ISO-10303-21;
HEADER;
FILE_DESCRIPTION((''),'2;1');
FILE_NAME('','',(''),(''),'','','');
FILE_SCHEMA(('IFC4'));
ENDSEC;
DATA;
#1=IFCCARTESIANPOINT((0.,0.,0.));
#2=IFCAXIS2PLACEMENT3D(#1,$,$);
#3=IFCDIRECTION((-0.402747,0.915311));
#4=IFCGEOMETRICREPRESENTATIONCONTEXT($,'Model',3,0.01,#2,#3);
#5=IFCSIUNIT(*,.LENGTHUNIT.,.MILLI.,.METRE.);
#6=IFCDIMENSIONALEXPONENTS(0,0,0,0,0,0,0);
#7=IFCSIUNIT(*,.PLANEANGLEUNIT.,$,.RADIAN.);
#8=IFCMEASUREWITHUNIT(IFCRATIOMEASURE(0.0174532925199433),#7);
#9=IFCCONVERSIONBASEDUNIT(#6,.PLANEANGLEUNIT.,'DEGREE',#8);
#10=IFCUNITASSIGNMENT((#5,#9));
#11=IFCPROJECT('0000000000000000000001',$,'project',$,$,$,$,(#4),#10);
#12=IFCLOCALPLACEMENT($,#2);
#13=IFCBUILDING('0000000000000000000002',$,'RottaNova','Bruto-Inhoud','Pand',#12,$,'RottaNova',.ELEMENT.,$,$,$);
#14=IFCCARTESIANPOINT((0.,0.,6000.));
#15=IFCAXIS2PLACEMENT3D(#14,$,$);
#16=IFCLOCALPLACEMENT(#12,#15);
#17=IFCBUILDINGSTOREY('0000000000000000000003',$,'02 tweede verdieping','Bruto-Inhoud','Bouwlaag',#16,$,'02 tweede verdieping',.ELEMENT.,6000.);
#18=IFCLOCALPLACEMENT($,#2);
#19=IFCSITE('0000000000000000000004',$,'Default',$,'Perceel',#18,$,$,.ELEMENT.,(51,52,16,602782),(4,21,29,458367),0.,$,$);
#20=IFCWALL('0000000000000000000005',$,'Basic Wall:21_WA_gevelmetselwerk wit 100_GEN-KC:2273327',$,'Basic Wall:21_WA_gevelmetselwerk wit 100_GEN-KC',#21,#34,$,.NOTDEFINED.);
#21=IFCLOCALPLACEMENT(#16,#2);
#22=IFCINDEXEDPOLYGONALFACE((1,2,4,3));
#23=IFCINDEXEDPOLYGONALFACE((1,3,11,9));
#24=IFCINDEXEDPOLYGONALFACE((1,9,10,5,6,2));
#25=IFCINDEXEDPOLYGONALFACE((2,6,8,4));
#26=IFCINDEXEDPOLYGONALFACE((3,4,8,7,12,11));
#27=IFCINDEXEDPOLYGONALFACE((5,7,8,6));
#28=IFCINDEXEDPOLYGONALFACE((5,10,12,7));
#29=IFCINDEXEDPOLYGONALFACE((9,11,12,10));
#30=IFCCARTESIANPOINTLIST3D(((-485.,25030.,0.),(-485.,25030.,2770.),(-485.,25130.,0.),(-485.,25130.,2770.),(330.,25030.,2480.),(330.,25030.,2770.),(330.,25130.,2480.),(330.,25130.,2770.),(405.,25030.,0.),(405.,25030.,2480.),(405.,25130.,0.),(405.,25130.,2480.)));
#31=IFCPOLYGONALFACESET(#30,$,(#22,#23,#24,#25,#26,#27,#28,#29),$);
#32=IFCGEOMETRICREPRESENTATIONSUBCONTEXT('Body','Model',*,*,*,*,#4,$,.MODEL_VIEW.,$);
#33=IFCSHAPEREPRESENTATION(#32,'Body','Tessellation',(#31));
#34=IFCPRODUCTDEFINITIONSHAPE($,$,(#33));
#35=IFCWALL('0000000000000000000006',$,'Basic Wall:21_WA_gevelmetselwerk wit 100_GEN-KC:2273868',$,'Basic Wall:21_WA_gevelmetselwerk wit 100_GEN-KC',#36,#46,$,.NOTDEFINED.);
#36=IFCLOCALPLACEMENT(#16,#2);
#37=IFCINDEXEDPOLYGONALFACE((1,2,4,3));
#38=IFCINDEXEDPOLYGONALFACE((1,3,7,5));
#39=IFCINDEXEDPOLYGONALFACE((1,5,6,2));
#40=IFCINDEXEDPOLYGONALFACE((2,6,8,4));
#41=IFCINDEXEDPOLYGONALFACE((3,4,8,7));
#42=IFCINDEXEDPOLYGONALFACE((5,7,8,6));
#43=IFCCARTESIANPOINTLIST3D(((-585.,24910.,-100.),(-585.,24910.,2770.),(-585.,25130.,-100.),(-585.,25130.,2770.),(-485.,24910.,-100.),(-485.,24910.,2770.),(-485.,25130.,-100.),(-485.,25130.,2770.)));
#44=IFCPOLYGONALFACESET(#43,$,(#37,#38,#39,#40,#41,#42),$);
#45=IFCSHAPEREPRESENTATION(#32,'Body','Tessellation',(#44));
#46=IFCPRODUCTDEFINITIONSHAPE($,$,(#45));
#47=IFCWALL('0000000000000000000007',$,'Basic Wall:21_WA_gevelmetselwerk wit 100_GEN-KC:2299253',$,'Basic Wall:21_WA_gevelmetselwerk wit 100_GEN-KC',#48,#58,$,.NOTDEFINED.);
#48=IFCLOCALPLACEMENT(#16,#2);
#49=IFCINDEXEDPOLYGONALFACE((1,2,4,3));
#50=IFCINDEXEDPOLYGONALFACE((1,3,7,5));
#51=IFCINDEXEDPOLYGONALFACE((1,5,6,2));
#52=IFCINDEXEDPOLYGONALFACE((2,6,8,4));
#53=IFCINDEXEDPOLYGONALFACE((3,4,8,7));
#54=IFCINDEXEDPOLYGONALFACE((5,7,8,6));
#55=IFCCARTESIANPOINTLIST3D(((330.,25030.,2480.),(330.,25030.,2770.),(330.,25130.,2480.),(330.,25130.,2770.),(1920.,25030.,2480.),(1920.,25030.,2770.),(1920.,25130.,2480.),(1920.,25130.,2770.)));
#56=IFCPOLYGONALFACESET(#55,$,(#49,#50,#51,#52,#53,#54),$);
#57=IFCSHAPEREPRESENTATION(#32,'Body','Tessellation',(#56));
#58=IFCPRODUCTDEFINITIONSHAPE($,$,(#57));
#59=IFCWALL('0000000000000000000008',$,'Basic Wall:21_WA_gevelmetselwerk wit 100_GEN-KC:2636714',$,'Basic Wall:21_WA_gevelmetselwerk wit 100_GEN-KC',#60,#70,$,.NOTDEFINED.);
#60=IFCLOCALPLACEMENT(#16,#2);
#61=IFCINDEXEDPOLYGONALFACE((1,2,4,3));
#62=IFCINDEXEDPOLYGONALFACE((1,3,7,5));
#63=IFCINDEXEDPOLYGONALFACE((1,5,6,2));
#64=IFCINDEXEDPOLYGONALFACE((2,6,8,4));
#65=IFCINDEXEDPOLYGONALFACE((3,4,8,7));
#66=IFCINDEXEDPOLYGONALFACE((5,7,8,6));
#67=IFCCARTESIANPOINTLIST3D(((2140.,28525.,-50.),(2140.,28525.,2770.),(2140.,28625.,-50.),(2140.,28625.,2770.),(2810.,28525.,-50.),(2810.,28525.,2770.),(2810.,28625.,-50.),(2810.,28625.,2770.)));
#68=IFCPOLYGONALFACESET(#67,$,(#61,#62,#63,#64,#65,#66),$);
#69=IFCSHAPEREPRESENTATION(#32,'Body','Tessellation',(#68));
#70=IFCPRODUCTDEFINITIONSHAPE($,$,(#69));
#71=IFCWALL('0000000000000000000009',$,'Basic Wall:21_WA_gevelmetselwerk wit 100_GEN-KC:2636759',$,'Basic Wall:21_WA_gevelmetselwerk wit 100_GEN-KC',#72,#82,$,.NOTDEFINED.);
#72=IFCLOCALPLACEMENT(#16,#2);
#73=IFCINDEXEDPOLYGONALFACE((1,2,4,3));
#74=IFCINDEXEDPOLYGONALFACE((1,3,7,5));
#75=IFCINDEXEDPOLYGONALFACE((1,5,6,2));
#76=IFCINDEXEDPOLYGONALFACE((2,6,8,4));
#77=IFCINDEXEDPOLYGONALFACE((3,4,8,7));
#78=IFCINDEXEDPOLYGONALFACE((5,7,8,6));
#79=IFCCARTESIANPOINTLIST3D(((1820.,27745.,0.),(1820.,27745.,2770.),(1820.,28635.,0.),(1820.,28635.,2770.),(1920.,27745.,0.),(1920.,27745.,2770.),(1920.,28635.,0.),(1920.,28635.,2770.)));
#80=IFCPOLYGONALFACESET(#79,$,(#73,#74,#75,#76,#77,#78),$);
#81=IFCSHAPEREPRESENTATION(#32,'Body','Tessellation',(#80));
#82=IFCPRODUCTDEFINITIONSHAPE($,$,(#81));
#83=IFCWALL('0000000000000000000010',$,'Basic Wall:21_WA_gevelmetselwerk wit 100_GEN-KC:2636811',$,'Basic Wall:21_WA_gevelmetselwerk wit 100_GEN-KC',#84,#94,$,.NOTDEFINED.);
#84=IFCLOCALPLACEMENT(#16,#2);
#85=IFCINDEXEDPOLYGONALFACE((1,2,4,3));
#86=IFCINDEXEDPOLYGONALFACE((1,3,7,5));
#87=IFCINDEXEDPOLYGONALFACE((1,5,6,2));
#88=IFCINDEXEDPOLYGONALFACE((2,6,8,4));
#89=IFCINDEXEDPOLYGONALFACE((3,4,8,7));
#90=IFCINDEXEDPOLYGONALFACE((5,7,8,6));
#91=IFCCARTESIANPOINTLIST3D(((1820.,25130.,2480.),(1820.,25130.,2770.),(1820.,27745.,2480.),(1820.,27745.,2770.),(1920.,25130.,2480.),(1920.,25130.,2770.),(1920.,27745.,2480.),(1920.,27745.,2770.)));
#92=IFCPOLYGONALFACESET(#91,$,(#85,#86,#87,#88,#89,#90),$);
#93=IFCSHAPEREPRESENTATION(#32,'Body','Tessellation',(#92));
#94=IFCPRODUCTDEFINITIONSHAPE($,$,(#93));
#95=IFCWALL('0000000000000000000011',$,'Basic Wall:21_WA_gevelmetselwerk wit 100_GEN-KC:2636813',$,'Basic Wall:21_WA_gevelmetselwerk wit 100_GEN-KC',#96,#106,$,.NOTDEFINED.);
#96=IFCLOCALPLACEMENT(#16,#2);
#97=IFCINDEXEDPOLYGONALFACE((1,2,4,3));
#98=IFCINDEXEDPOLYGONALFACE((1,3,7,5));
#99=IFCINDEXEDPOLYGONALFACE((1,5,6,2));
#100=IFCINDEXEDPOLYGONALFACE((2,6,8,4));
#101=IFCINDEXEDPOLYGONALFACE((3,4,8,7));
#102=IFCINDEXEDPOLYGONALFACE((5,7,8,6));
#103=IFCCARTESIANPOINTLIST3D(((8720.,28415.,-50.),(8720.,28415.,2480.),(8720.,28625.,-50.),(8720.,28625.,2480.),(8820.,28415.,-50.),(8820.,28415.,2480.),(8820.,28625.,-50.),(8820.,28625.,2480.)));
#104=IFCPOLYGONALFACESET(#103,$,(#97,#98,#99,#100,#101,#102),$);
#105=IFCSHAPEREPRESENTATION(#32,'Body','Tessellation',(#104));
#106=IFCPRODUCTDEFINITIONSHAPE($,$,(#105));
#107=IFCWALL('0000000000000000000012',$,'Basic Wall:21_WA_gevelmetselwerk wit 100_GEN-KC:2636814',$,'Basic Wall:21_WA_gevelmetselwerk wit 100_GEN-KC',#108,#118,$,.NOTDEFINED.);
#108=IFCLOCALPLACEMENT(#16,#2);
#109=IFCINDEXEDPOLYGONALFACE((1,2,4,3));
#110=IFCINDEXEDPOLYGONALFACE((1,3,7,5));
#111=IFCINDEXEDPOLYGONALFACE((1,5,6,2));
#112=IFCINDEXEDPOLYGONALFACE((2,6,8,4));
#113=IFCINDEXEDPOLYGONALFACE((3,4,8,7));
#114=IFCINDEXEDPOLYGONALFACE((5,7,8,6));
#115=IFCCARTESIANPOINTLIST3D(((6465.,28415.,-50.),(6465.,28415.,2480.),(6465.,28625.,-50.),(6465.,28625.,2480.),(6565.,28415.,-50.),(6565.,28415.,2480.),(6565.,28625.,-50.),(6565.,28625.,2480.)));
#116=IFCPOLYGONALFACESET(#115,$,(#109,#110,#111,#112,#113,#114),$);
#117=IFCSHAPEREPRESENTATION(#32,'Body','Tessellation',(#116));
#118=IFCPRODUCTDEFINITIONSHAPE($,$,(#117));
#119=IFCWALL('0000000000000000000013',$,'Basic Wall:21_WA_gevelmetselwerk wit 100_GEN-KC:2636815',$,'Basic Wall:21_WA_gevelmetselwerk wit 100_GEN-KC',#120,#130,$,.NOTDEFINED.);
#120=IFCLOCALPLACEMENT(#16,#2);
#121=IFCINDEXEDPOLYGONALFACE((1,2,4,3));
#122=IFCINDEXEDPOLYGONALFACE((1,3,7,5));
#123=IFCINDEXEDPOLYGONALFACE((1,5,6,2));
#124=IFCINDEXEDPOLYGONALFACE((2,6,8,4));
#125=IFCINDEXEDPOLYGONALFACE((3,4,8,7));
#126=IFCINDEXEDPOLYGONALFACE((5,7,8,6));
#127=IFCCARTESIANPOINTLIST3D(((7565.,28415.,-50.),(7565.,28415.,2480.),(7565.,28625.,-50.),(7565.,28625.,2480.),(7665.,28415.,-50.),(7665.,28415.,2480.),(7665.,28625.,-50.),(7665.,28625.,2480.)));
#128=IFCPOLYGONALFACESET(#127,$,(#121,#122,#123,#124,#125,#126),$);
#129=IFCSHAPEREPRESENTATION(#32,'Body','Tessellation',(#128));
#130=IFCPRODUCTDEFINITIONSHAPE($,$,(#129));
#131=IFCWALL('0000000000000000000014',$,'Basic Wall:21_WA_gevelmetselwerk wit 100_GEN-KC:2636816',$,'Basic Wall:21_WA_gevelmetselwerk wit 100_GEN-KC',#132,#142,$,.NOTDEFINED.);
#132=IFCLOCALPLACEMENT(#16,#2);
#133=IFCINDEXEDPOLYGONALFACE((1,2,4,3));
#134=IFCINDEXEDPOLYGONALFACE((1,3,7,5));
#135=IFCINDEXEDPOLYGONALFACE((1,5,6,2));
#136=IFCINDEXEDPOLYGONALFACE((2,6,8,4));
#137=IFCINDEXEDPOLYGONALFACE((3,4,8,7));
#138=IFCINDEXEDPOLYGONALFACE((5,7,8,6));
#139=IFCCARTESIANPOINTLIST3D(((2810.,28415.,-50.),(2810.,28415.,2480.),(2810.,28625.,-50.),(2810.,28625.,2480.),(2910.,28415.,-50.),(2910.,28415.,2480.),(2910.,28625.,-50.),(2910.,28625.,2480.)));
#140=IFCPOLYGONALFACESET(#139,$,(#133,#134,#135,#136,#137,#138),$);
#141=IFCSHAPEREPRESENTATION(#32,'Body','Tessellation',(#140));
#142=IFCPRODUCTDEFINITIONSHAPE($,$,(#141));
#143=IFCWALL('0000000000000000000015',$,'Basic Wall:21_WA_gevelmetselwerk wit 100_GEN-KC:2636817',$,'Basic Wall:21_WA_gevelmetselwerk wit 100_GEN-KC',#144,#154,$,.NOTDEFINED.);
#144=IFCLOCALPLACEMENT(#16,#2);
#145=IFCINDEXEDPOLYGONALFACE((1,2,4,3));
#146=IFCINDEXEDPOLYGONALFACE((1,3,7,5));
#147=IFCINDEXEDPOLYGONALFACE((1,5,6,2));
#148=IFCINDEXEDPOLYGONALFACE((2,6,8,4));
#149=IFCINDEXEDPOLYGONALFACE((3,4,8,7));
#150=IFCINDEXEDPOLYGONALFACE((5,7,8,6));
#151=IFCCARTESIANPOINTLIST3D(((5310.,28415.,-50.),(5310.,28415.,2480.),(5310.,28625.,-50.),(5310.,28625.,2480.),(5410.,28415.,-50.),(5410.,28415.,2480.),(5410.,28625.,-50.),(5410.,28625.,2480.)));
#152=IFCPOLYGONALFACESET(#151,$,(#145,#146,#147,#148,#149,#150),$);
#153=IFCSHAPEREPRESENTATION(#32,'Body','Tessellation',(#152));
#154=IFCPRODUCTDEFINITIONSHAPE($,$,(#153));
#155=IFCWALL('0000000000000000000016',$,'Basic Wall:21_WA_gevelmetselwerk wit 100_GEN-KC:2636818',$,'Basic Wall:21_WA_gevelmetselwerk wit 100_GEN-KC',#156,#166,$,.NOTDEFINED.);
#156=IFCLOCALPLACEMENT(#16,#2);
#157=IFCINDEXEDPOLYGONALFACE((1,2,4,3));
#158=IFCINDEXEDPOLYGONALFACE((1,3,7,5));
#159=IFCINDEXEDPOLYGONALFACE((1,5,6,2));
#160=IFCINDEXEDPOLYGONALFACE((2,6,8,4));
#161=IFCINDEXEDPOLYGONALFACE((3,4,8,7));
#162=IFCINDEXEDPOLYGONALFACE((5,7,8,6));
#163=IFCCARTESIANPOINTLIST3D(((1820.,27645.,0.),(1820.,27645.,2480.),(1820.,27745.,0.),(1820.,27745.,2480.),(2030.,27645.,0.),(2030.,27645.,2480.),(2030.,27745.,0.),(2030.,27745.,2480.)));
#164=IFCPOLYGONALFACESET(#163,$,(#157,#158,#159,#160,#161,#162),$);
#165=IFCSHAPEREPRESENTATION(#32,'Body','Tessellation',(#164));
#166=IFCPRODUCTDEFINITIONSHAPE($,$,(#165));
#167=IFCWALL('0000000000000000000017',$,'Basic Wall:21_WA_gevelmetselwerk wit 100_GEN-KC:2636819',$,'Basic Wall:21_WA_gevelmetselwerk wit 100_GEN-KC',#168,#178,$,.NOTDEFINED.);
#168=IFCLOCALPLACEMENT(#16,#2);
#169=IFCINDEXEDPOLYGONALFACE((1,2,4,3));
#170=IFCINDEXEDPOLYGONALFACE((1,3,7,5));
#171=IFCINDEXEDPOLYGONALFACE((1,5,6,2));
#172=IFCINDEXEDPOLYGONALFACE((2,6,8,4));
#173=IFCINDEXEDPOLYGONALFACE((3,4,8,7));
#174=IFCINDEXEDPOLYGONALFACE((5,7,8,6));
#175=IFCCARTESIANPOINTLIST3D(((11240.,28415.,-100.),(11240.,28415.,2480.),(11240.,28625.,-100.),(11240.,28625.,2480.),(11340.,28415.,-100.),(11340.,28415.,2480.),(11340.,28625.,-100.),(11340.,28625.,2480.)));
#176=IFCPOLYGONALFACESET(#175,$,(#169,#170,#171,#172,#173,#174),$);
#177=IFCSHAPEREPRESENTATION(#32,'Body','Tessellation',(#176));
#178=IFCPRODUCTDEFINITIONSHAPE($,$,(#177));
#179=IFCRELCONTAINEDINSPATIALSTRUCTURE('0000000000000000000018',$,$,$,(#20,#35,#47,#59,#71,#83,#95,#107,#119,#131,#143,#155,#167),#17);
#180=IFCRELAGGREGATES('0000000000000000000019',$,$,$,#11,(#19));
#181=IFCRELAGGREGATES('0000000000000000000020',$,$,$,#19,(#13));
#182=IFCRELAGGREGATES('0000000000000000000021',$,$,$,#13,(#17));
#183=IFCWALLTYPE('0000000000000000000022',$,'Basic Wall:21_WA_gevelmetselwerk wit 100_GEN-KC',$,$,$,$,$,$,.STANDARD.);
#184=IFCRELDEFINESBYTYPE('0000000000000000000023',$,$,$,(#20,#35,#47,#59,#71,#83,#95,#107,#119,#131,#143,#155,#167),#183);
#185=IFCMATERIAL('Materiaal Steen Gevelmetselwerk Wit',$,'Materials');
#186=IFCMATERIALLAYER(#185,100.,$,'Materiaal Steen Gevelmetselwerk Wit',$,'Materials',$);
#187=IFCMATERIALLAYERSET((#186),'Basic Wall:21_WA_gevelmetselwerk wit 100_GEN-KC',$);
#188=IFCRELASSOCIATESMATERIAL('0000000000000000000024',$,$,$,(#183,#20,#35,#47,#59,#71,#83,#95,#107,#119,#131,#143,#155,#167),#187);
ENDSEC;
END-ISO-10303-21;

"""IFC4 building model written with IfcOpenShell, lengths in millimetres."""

from ifc_helpers import new_model, entity, si_unit, converted_unit, direction, frame, frame_2d, origin, place, context, subcontext, project, spatial, polyline, rectangle, extrude, clip, bounded_halfspace, material, layer, layer_set, type_object, element, save


model = new_model("IFC4")

# Units and contexts
model_context = context("Model", 3, precision=0.01, world=origin(), true_north=direction((-0.402747, 0.915311)))
body_context = subcontext(model_context, "Body", "Model", "MODEL_VIEW")
ifc_project = project(units=[si_unit("LENGTHUNIT", "METRE", prefix="MILLI"), converted_unit("PLANEANGLEUNIT", "DEGREE", entity("IfcRatioMeasure", 0.0174532925199433), si_unit("PLANEANGLEUNIT", "RADIAN"), dimensions=[0, 0, 0, 0, 0, 0, 0])], contexts=[model_context])

# Site, building, storey
site_placement = place(None, origin())
site = spatial("IfcSite", under=ifc_project, at=site_placement, Name="Default", ObjectType="Perceel", CompositionType="ELEMENT", RefLatitude=(51, 52, 16, 602782), RefLongitude=(4, 21, 29, 458367), RefElevation=0.0)
building_placement = place(None, origin())
building = spatial("IfcBuilding", under=site, at=building_placement, Name="RottaNova", Description="Bruto-Inhoud", ObjectType="Pand", LongName="RottaNova", CompositionType="ELEMENT")
storey_placement = place(building_placement, frame((0.0, 0.0, 6000.0)))
storey = spatial("IfcBuildingStorey", under=building, at=storey_placement, Name="02 tweede verdieping", Description="Bruto-Inhoud", ObjectType="Bouwlaag", LongName="02 tweede verdieping", CompositionType="ELEMENT", Elevation=6000.0)

# Walls
ifc_material = material(Name="Materiaal Steen Gevelmetselwerk Wit", Category="Materials")
ifc_layer = layer(ifc_material, 100.0, Name="Materiaal Steen Gevelmetselwerk Wit", Category="Materials")
ifc_layer_set = layer_set([ifc_layer], Name="Basic Wall:21_WA_gevelmetselwerk wit 100_GEN-KC")
wall_type = type_object("IfcWallType", Name="Basic Wall:21_WA_gevelmetselwerk wit 100_GEN-KC", PredefinedType="STANDARD", material=ifc_layer_set)
wall_1_placement = place(storey_placement, frame((-485.0, 25080.0, 0.0)))
element("IfcWall", 1, at=wall_1_placement, inside=storey, type_object=wall_type, material=ifc_layer_set, Name="Basic Wall:21_WA_gevelmetselwerk wit 100_GEN-KC:2273327", ObjectType="Basic Wall:21_WA_gevelmetselwerk wit 100_GEN-KC", PredefinedType="NOTDEFINED", context=body_context, shape_type="Clipping", body=[
    clip(clip(extrude(rectangle(XDim=890.0, YDim=100.0, at=frame_2d((445.0, 0.0), x_axis=(-1.0, 0.0))), origin(), (0.0, 0.0, 1.0), 2770.0), bounded_halfspace(frame((815.0, 50.0, 2480.0), z_axis=(0.0, 0.0, -1.0), x_axis=(0.0, 1.0, 0.0)), True, frame((815.0, 50.0, 2480.0), z_axis=(0.0, 0.0, -1.0), x_axis=(0.0, 1.0, 0.0)), polyline([(0.0, 0.0), (0.0, 75.0), (-100.0, 75.0), (-100.0, 0.0), (0.0, 0.0)]))), bounded_halfspace(frame((815.0, -50.0, 2480.0), z_axis=(-1.0, 0.0, 0.0), x_axis=(0.0, 1.0, 0.0)), True, frame((815.0, -50.0, 2480.0), z_axis=(-1.0, 0.0, 0.0), x_axis=(0.0, 1.0, 0.0)), polyline([(0.0, 0.0), (0.0, -88392.0), (30480.0, -88392.0), (30480.0, 0.0), (0.0, 0.0)]))),
])
wall_2_placement = place(storey_placement, frame((-535.0, 25130.0, -100.0), z_axis=(0.0, 0.0, 1.0), x_axis=(0.0, -1.0, 0.0)))
element("IfcWall", 2, at=wall_2_placement, inside=storey, type_object=wall_type, material=ifc_layer_set, Name="Basic Wall:21_WA_gevelmetselwerk wit 100_GEN-KC:2273868", ObjectType="Basic Wall:21_WA_gevelmetselwerk wit 100_GEN-KC", PredefinedType="NOTDEFINED", context=body_context, shape_type="SweptSolid", body=[
    extrude(rectangle(XDim=220.0, YDim=100.0, at=frame_2d((110.0, 0.0), x_axis=(-1.0, 0.0))), origin(), (0.0, 0.0, 1.0), 2870.0),
])
wall_3_placement = place(storey_placement, frame((330.0, 25080.0, 2480.0)))
element("IfcWall", 3, at=wall_3_placement, inside=storey, type_object=wall_type, material=ifc_layer_set, Name="Basic Wall:21_WA_gevelmetselwerk wit 100_GEN-KC:2299253", ObjectType="Basic Wall:21_WA_gevelmetselwerk wit 100_GEN-KC", PredefinedType="NOTDEFINED", context=body_context, shape_type="SweptSolid", body=[
    extrude(rectangle(XDim=1590.0, YDim=100.0, at=frame_2d((795.0, 0.0), x_axis=(-1.0, 0.0))), origin(), (0.0, 0.0, 1.0), 290.0),
])
wall_4_placement = place(storey_placement, frame((2140.0, 28575.0, -50.0)))
element("IfcWall", 4, at=wall_4_placement, inside=storey, type_object=wall_type, material=ifc_layer_set, Name="Basic Wall:21_WA_gevelmetselwerk wit 100_GEN-KC:2636714", ObjectType="Basic Wall:21_WA_gevelmetselwerk wit 100_GEN-KC", PredefinedType="NOTDEFINED", context=body_context, shape_type="SweptSolid", body=[
    extrude(rectangle(XDim=670.0, YDim=100.0, at=frame_2d((335.0, 0.0), x_axis=(-1.0, 0.0))), origin(), (0.0, 0.0, 1.0), 2820.0),
])
wall_5_placement = place(storey_placement, frame((1870.0, 27745.0, 0.0), z_axis=(0.0, 0.0, 1.0), x_axis=(0.0, 1.0, 0.0)))
element("IfcWall", 5, at=wall_5_placement, inside=storey, type_object=wall_type, material=ifc_layer_set, Name="Basic Wall:21_WA_gevelmetselwerk wit 100_GEN-KC:2636759", ObjectType="Basic Wall:21_WA_gevelmetselwerk wit 100_GEN-KC", PredefinedType="NOTDEFINED", context=body_context, shape_type="SweptSolid", body=[
    extrude(rectangle(XDim=890.0, YDim=100.0, at=frame_2d((445.0, 0.0), x_axis=(-1.0, 0.0))), origin(), (0.0, 0.0, 1.0), 2770.0),
])
wall_6_placement = place(storey_placement, frame((1870.0, 25130.0, 2480.0), z_axis=(0.0, 0.0, 1.0), x_axis=(0.0, 1.0, 0.0)))
element("IfcWall", 6, at=wall_6_placement, inside=storey, type_object=wall_type, material=ifc_layer_set, Name="Basic Wall:21_WA_gevelmetselwerk wit 100_GEN-KC:2636811", ObjectType="Basic Wall:21_WA_gevelmetselwerk wit 100_GEN-KC", PredefinedType="NOTDEFINED", context=body_context, shape_type="SweptSolid", body=[
    extrude(rectangle(XDim=2615.0, YDim=100.0, at=frame_2d((1307.5, 0.0), x_axis=(-1.0, 0.0))), origin(), (0.0, 0.0, 1.0), 290.0),
])
wall_7_placement = place(storey_placement, frame((8770.0, 28415.0, -50.0), z_axis=(0.0, 0.0, 1.0), x_axis=(0.0, 1.0, 0.0)))
element("IfcWall", 7, at=wall_7_placement, inside=storey, type_object=wall_type, material=ifc_layer_set, Name="Basic Wall:21_WA_gevelmetselwerk wit 100_GEN-KC:2636813", ObjectType="Basic Wall:21_WA_gevelmetselwerk wit 100_GEN-KC", PredefinedType="NOTDEFINED", context=body_context, shape_type="SweptSolid", body=[
    extrude(rectangle(XDim=210.0, YDim=100.0, at=frame_2d((105.0, 0.0), x_axis=(-1.0, 0.0))), origin(), (0.0, 0.0, 1.0), 2530.0),
])
wall_8_placement = place(storey_placement, frame((6515.0, 28415.0, -50.0), z_axis=(0.0, 0.0, 1.0), x_axis=(0.0, 1.0, 0.0)))
element("IfcWall", 8, at=wall_8_placement, inside=storey, type_object=wall_type, material=ifc_layer_set, Name="Basic Wall:21_WA_gevelmetselwerk wit 100_GEN-KC:2636814", ObjectType="Basic Wall:21_WA_gevelmetselwerk wit 100_GEN-KC", PredefinedType="NOTDEFINED", context=body_context, shape_type="SweptSolid", body=[
    extrude(rectangle(XDim=210.0, YDim=100.0, at=frame_2d((105.0, 0.0), x_axis=(-1.0, 0.0))), origin(), (0.0, 0.0, 1.0), 2530.0),
])
wall_9_placement = place(storey_placement, frame((7615.0, 28415.0, -50.0), z_axis=(0.0, 0.0, 1.0), x_axis=(0.0, 1.0, 0.0)))
element("IfcWall", 9, at=wall_9_placement, inside=storey, type_object=wall_type, material=ifc_layer_set, Name="Basic Wall:21_WA_gevelmetselwerk wit 100_GEN-KC:2636815", ObjectType="Basic Wall:21_WA_gevelmetselwerk wit 100_GEN-KC", PredefinedType="NOTDEFINED", context=body_context, shape_type="SweptSolid", body=[
    extrude(rectangle(XDim=210.0, YDim=100.0, at=frame_2d((105.0, 0.0), x_axis=(-1.0, 0.0))), origin(), (0.0, 0.0, 1.0), 2530.0),
])
wall_10_placement = place(storey_placement, frame((2860.0, 28415.0, -50.0), z_axis=(0.0, 0.0, 1.0), x_axis=(0.0, 1.0, 0.0)))
element("IfcWall", 10, at=wall_10_placement, inside=storey, type_object=wall_type, material=ifc_layer_set, Name="Basic Wall:21_WA_gevelmetselwerk wit 100_GEN-KC:2636816", ObjectType="Basic Wall:21_WA_gevelmetselwerk wit 100_GEN-KC", PredefinedType="NOTDEFINED", context=body_context, shape_type="SweptSolid", body=[
    extrude(rectangle(XDim=210.0, YDim=100.0, at=frame_2d((105.0, 0.0), x_axis=(-1.0, 0.0))), origin(), (0.0, 0.0, 1.0), 2530.0),
])
wall_11_placement = place(storey_placement, frame((5360.0, 28415.0, -50.0), z_axis=(0.0, 0.0, 1.0), x_axis=(0.0, 1.0, 0.0)))
element("IfcWall", 11, at=wall_11_placement, inside=storey, type_object=wall_type, material=ifc_layer_set, Name="Basic Wall:21_WA_gevelmetselwerk wit 100_GEN-KC:2636817", ObjectType="Basic Wall:21_WA_gevelmetselwerk wit 100_GEN-KC", PredefinedType="NOTDEFINED", context=body_context, shape_type="SweptSolid", body=[
    extrude(rectangle(XDim=210.0, YDim=100.0, at=frame_2d((105.0, 0.0), x_axis=(-1.0, 0.0))), origin(), (0.0, 0.0, 1.0), 2530.0),
])
wall_12_placement = place(storey_placement, frame((2030.0, 27695.0, 0.0), z_axis=(0.0, 0.0, 1.0), x_axis=(-1.0, 0.0, 0.0)))
element("IfcWall", 12, at=wall_12_placement, inside=storey, type_object=wall_type, material=ifc_layer_set, Name="Basic Wall:21_WA_gevelmetselwerk wit 100_GEN-KC:2636818", ObjectType="Basic Wall:21_WA_gevelmetselwerk wit 100_GEN-KC", PredefinedType="NOTDEFINED", context=body_context, shape_type="SweptSolid", body=[
    extrude(rectangle(XDim=210.0, YDim=100.0, at=frame_2d((105.0, 0.0), x_axis=(-1.0, 0.0))), origin(), (0.0, 0.0, 1.0), 2480.0),
])
wall_13_placement = place(storey_placement, frame((11290.0, 28415.0, -100.0), z_axis=(0.0, 0.0, 1.0), x_axis=(0.0, 1.0, 0.0)))
element("IfcWall", 13, at=wall_13_placement, inside=storey, type_object=wall_type, material=ifc_layer_set, Name="Basic Wall:21_WA_gevelmetselwerk wit 100_GEN-KC:2636819", ObjectType="Basic Wall:21_WA_gevelmetselwerk wit 100_GEN-KC", PredefinedType="NOTDEFINED", context=body_context, shape_type="SweptSolid", body=[
    extrude(rectangle(XDim=210.0, YDim=100.0, at=frame_2d((105.0, 0.0), x_axis=(-1.0, 0.0))), origin(), (0.0, 0.0, 1.0), 2580.0),
])

save(model, "model.ifc")
